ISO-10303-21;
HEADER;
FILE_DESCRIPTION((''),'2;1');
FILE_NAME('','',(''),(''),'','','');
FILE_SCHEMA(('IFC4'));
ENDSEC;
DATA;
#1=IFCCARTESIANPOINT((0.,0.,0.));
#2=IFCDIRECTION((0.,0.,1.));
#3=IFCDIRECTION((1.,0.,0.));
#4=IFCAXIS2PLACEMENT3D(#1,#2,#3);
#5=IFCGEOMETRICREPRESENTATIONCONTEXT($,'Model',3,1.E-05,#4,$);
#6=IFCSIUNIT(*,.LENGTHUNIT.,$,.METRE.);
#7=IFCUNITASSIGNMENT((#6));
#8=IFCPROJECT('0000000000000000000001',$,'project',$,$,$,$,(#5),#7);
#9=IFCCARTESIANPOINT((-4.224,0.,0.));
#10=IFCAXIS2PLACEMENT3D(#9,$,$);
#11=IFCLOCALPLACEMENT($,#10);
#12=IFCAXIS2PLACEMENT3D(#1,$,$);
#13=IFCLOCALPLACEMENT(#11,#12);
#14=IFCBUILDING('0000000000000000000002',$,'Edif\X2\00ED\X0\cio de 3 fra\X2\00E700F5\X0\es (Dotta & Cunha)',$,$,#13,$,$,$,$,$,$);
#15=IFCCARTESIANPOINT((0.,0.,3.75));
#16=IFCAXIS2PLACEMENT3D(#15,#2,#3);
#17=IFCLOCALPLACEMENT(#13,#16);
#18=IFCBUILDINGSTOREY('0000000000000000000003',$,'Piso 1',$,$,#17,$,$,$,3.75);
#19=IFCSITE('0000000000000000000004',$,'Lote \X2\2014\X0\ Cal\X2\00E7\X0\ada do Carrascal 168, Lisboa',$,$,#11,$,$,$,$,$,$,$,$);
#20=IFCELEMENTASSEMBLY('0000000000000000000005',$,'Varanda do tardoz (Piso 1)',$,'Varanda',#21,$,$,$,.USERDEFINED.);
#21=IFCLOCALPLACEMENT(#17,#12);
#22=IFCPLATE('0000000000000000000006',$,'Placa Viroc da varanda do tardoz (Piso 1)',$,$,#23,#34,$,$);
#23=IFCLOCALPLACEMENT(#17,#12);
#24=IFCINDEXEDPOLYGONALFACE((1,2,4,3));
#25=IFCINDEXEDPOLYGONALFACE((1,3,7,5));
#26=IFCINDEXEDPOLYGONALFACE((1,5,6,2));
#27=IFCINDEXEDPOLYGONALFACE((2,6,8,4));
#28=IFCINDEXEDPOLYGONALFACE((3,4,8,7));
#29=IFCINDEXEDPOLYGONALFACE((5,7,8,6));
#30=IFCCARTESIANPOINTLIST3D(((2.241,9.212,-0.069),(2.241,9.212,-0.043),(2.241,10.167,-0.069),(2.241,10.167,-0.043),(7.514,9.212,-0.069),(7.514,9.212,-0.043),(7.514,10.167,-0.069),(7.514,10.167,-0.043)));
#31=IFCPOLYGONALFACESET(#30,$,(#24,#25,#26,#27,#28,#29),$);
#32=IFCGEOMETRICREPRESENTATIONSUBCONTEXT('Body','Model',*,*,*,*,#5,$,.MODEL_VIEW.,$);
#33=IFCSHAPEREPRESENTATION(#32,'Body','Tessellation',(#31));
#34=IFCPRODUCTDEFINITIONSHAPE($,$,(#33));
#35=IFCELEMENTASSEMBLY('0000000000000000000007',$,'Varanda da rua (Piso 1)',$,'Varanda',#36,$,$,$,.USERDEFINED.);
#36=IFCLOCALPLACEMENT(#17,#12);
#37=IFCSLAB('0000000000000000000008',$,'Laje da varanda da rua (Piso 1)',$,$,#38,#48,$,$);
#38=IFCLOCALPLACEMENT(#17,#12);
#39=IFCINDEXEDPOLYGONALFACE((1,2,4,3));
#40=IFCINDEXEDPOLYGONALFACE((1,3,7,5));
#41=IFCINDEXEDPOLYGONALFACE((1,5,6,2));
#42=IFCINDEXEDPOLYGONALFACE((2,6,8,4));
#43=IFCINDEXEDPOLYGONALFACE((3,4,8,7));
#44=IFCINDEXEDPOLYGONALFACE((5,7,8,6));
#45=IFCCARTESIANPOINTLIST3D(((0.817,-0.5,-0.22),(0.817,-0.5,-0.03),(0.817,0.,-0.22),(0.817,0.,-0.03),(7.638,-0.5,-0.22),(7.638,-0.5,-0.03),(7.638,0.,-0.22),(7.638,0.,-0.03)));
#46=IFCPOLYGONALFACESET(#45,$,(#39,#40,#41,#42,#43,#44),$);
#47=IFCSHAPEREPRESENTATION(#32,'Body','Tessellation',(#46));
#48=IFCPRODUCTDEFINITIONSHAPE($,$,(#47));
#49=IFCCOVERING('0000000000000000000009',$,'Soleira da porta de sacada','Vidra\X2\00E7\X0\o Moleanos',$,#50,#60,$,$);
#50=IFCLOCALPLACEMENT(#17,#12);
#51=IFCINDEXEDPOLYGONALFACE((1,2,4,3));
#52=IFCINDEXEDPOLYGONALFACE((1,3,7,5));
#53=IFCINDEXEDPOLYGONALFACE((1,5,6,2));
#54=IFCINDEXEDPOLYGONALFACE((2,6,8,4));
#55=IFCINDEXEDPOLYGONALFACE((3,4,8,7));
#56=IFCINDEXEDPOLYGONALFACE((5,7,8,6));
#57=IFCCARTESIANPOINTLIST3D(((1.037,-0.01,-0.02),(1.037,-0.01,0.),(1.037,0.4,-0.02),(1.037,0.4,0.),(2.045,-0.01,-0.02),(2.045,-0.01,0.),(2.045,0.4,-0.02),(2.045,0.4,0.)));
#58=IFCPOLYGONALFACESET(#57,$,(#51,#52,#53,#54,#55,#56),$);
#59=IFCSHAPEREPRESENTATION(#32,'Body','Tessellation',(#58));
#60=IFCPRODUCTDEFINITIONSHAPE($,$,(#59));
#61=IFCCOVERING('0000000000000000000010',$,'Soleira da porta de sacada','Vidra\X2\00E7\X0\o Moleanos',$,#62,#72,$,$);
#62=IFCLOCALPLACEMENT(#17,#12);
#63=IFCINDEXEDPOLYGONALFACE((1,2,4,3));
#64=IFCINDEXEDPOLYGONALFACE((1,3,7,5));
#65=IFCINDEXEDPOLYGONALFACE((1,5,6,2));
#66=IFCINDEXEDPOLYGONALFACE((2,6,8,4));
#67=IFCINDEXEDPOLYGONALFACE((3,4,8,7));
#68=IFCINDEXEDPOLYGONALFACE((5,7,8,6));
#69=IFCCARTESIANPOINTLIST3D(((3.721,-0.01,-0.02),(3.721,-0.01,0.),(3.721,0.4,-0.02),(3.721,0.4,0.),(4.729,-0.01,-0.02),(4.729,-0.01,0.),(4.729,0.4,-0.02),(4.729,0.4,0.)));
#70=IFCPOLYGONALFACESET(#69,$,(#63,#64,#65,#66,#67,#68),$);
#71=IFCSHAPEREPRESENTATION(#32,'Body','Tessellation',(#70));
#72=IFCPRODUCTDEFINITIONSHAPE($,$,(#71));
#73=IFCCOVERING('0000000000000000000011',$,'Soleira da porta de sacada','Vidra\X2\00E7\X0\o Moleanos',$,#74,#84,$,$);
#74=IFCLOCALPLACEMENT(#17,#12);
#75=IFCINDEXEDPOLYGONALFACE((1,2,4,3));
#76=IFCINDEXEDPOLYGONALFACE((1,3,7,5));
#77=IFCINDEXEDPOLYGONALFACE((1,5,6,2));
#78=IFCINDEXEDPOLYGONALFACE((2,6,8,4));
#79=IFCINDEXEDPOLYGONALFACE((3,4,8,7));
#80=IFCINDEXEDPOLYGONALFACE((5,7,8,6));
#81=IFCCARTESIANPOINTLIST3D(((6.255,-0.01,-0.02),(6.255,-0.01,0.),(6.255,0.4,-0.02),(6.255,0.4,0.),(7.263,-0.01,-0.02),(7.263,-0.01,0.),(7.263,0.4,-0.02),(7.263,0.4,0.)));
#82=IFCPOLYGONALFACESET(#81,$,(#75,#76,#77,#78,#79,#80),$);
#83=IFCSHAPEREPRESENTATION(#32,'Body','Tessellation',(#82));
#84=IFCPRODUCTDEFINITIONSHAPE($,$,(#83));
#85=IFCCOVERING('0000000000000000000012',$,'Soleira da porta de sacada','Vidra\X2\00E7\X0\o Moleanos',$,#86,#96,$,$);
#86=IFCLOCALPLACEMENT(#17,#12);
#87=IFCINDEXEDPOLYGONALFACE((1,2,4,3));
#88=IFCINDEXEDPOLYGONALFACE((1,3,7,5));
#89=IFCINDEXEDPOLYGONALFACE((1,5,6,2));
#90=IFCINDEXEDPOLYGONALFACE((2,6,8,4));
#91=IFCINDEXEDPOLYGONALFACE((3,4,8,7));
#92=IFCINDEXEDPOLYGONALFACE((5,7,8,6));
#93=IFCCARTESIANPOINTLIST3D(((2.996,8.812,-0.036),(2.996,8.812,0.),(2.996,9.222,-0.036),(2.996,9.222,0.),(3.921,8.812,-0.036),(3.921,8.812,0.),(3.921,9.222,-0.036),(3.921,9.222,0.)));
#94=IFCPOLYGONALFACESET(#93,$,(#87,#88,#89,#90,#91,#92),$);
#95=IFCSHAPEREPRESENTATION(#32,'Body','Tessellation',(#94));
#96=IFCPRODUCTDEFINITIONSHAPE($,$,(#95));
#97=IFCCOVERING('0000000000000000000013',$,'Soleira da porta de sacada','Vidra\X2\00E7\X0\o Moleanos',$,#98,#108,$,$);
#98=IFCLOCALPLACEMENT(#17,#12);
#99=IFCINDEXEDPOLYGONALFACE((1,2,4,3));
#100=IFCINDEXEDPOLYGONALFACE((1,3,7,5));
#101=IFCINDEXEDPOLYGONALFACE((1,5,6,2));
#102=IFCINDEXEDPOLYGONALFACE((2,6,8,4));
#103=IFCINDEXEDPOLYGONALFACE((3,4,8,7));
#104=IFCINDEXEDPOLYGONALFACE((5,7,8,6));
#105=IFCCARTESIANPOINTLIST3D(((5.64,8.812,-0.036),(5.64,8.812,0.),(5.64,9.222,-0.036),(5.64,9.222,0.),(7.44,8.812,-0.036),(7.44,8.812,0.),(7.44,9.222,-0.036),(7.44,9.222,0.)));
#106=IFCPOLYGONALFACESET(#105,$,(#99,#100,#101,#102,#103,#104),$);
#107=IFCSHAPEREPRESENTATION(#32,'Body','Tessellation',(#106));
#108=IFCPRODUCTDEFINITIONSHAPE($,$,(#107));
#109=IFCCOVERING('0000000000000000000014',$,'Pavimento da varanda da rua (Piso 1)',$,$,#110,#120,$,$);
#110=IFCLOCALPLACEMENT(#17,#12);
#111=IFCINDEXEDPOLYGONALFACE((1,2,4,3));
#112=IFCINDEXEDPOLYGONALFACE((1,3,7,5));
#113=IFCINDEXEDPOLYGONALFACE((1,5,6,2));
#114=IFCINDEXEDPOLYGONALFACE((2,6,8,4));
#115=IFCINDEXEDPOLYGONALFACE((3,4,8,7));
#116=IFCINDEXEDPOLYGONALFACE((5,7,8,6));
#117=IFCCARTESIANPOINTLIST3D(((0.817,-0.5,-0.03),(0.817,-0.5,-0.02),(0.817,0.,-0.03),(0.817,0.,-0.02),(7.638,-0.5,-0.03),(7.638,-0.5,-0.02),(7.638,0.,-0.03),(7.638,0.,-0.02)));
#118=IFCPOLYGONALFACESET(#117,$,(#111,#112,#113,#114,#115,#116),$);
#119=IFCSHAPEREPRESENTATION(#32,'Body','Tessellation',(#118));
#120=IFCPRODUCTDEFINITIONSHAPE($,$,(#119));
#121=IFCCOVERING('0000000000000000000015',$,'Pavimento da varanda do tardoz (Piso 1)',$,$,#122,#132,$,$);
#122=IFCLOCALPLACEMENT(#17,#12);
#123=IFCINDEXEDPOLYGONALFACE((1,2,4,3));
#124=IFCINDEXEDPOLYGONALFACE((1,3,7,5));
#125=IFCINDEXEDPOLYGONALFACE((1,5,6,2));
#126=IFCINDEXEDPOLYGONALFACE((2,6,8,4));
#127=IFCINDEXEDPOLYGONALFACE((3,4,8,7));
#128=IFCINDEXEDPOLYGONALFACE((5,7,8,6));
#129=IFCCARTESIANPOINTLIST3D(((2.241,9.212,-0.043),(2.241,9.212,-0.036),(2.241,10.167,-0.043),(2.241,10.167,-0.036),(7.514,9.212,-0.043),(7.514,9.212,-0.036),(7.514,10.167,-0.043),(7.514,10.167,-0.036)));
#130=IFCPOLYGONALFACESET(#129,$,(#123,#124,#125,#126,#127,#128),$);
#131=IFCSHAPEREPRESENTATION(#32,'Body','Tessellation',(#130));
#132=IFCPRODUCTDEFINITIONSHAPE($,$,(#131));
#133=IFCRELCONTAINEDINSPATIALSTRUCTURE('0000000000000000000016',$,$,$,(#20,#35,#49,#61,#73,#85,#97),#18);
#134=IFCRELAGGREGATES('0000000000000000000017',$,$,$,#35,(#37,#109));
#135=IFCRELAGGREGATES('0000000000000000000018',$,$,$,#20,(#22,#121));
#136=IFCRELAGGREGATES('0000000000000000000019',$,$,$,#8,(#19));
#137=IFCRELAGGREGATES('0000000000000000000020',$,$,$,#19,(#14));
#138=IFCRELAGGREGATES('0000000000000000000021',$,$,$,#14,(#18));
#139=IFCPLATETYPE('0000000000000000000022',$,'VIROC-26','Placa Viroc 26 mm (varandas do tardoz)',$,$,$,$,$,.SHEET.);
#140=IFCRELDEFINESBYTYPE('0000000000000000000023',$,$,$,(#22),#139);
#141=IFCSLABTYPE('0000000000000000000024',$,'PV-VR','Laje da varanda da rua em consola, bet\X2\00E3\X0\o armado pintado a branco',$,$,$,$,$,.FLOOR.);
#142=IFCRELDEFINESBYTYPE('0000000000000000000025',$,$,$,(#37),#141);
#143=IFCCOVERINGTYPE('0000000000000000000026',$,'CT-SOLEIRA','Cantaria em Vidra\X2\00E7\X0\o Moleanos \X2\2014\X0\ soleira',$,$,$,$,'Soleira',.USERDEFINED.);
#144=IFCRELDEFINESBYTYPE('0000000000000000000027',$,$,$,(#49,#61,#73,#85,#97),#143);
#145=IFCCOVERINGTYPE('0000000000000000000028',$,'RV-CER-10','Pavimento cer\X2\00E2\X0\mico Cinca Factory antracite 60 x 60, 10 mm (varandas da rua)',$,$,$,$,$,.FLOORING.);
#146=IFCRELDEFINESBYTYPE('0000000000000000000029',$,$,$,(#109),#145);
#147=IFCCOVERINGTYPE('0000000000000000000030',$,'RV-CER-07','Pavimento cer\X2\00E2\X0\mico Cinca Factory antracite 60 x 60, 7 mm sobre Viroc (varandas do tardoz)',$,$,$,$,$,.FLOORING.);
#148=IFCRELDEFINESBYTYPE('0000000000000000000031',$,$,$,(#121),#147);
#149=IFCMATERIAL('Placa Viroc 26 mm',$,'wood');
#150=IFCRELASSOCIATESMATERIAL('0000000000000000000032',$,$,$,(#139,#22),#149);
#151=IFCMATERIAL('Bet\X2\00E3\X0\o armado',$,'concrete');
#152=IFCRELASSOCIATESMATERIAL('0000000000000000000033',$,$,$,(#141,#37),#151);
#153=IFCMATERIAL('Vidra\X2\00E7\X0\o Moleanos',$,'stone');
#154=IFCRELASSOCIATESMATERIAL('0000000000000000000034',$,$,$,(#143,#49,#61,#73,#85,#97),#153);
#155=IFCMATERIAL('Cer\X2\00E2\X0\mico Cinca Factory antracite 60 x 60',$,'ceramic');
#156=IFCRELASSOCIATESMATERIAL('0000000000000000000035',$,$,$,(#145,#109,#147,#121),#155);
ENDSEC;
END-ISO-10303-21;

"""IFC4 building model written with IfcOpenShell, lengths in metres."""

from ifc_helpers import new_model, si_unit, frame, origin, origin_with_axes, place, context, subcontext, project, spatial, line, indexed_curve, outline, extrude, material, type_object, element, aggregate, save


model = new_model("IFC4")

# Units and contexts
model_context = context("Model", 3, precision=1e-05, world=origin_with_axes())
body_context = subcontext(model_context, "Body", "Model", "MODEL_VIEW")
ifc_project = project(units=[si_unit("LENGTHUNIT", "METRE")], contexts=[model_context])

# Site, building, storey
site_placement = place(None, frame((-4.224, 0.0, 0.0)))
site = spatial("IfcSite", under=ifc_project, at=site_placement, Name="Lote — Calçada do Carrascal 168, Lisboa")
building_placement = place(site_placement, origin())
building = spatial("IfcBuilding", under=site, at=building_placement, Name="Edifício de 3 frações (Dotta & Cunha)")
storey_placement = place(building_placement, frame((0.0, 0.0, 3.75), z_axis=(0.0, 0.0, 1.0), x_axis=(1.0, 0.0, 0.0)))
storey = spatial("IfcBuildingStorey", under=building, at=storey_placement, Name="Piso 1", Elevation=3.75)

# Element assembly, plate
assembly_1 = element("IfcElementAssembly", 1, inside=storey, Name="Varanda do tardoz (Piso 1)", ObjectType="Varanda", PredefinedType="USERDEFINED")
ifc_material_1 = material(Name="Placa Viroc 26 mm", Category="wood")
plate_type = type_object("IfcPlateType", Name="VIROC-26", Description="Placa Viroc 26 mm (varandas do tardoz)", PredefinedType="SHEET", material=ifc_material_1)
plate_placement = place(building_placement, frame((0.0, 0.0, 3.681), z_axis=(0.0, 0.0, 1.0), x_axis=(1.0, 0.0, 0.0)))
plate = element("IfcPlate", 2, at=plate_placement, type_object=plate_type, material=ifc_material_1, Name="Placa Viroc da varanda do tardoz (Piso 1)", context=body_context, shape_type="SweptSolid", body=[
    extrude(outline(indexed_curve([(7.514, 9.212), (7.514, 10.167), (2.241, 10.167), (2.241, 9.212)], segments=[line(1, 2, 3, 4, 1)])), origin_with_axes(), (0.0, 0.0, 1.0), 0.026),
])

# Element assembly, slab
assembly_2 = element("IfcElementAssembly", 3, inside=storey, Name="Varanda da rua (Piso 1)", ObjectType="Varanda", PredefinedType="USERDEFINED")
ifc_material_2 = material(Name="Betão armado", Category="concrete")
slab_type = type_object("IfcSlabType", Name="PV-VR", Description="Laje da varanda da rua em consola, betão armado pintado a branco", PredefinedType="FLOOR", material=ifc_material_2)
slab_placement = place(building_placement, frame((0.0, 0.0, 3.53), z_axis=(0.0, 0.0, 1.0), x_axis=(1.0, 0.0, 0.0)))
slab = element("IfcSlab", 4, at=slab_placement, type_object=slab_type, material=ifc_material_2, Name="Laje da varanda da rua (Piso 1)", context=body_context, shape_type="SweptSolid", body=[
    extrude(outline(indexed_curve([(7.638, -0.5), (7.638, 0.0), (0.817, 0.0), (0.817, -0.5)], segments=[line(1, 2, 3, 4, 1)])), origin_with_axes(), (0.0, 0.0, 1.0), 0.19),
])

# Coverings
ifc_material_3 = material(Name="Vidraço Moleanos", Category="stone")
covering_type_1 = type_object("IfcCoveringType", Name="CT-SOLEIRA", Description="Cantaria em Vidraço Moleanos — soleira", ElementType="Soleira", PredefinedType="USERDEFINED", material=ifc_material_3)
covering_1_placement = place(storey_placement, frame((0.0, 0.0, -0.02), z_axis=(0.0, 0.0, 1.0), x_axis=(1.0, 0.0, 0.0)))
element("IfcCovering", 5, at=covering_1_placement, inside=storey, type_object=covering_type_1, material=ifc_material_3, Name="Soleira da porta de sacada", Description="Vidraço Moleanos", context=body_context, shape_type="SweptSolid", body=[
    extrude(outline(indexed_curve([(2.045, -0.01), (2.045, 0.4), (1.037, 0.4), (1.037, -0.01)], segments=[line(1, 2, 3, 4, 1)])), origin_with_axes(), (0.0, 0.0, 1.0), 0.02),
])
covering_2_placement = place(storey_placement, frame((0.0, 0.0, -0.02), z_axis=(0.0, 0.0, 1.0), x_axis=(1.0, 0.0, 0.0)))
element("IfcCovering", 6, at=covering_2_placement, inside=storey, type_object=covering_type_1, material=ifc_material_3, Name="Soleira da porta de sacada", Description="Vidraço Moleanos", context=body_context, shape_type="SweptSolid", body=[
    extrude(outline(indexed_curve([(4.729, -0.01), (4.729, 0.4), (3.721, 0.4), (3.721, -0.01)], segments=[line(1, 2, 3, 4, 1)])), origin_with_axes(), (0.0, 0.0, 1.0), 0.02),
])
covering_3_placement = place(storey_placement, frame((0.0, 0.0, -0.02), z_axis=(0.0, 0.0, 1.0), x_axis=(1.0, 0.0, 0.0)))
element("IfcCovering", 7, at=covering_3_placement, inside=storey, type_object=covering_type_1, material=ifc_material_3, Name="Soleira da porta de sacada", Description="Vidraço Moleanos", context=body_context, shape_type="SweptSolid", body=[
    extrude(outline(indexed_curve([(7.263, -0.01), (7.263, 0.4), (6.255, 0.4), (6.255, -0.01)], segments=[line(1, 2, 3, 4, 1)])), origin_with_axes(), (0.0, 0.0, 1.0), 0.02),
])
covering_4_placement = place(storey_placement, frame((0.0, 0.0, -0.036), z_axis=(0.0, 0.0, 1.0), x_axis=(1.0, 0.0, 0.0)))
element("IfcCovering", 8, at=covering_4_placement, inside=storey, type_object=covering_type_1, material=ifc_material_3, Name="Soleira da porta de sacada", Description="Vidraço Moleanos", context=body_context, shape_type="SweptSolid", body=[
    extrude(outline(indexed_curve([(3.921, 8.812), (3.921, 9.222), (2.996, 9.222), (2.996, 8.812)], segments=[line(1, 2, 3, 4, 1)])), origin_with_axes(), (0.0, 0.0, 1.0), 0.036),
])
covering_5_placement = place(storey_placement, frame((0.0, 0.0, -0.036), z_axis=(0.0, 0.0, 1.0), x_axis=(1.0, 0.0, 0.0)))
element("IfcCovering", 9, at=covering_5_placement, inside=storey, type_object=covering_type_1, material=ifc_material_3, Name="Soleira da porta de sacada", Description="Vidraço Moleanos", context=body_context, shape_type="SweptSolid", body=[
    extrude(outline(indexed_curve([(7.44, 8.812), (7.44, 9.222), (5.64, 9.222), (5.64, 8.812)], segments=[line(1, 2, 3, 4, 1)])), origin_with_axes(), (0.0, 0.0, 1.0), 0.036),
])

# Coverings
ifc_material_4 = material(Name="Cerâmico Cinca Factory antracite 60 x 60", Category="ceramic")
covering_type_2 = type_object("IfcCoveringType", Name="RV-CER-10", Description="Pavimento cerâmico Cinca Factory antracite 60 x 60, 10 mm (varandas da rua)", PredefinedType="FLOORING", material=ifc_material_4)
covering_6_placement = place(building_placement, frame((0.0, 0.0, 3.72), z_axis=(0.0, 0.0, 1.0), x_axis=(1.0, 0.0, 0.0)))
covering_6 = element("IfcCovering", 10, at=covering_6_placement, type_object=covering_type_2, material=ifc_material_4, Name="Pavimento da varanda da rua (Piso 1)", context=body_context, shape_type="SweptSolid", body=[
    extrude(outline(indexed_curve([(7.638, -0.5), (7.638, 0.0), (0.817, 0.0), (0.817, -0.5)], segments=[line(1, 2, 3, 4, 1)])), origin_with_axes(), (0.0, 0.0, 1.0), 0.01),
])
aggregate(assembly_2, [slab, covering_6])
covering_type_3 = type_object("IfcCoveringType", Name="RV-CER-07", Description="Pavimento cerâmico Cinca Factory antracite 60 x 60, 7 mm sobre Viroc (varandas do tardoz)", PredefinedType="FLOORING", material=ifc_material_4)
covering_7_placement = place(building_placement, frame((0.0, 0.0, 3.707), z_axis=(0.0, 0.0, 1.0), x_axis=(1.0, 0.0, 0.0)))
covering_7 = element("IfcCovering", 11, at=covering_7_placement, type_object=covering_type_3, material=ifc_material_4, Name="Pavimento da varanda do tardoz (Piso 1)", context=body_context, shape_type="SweptSolid", body=[
    extrude(outline(indexed_curve([(7.514, 9.212), (7.514, 10.167), (2.241, 10.167), (2.241, 9.212)], segments=[line(1, 2, 3, 4, 1)])), origin_with_axes(), (0.0, 0.0, 1.0), 0.007),
])
aggregate(assembly_1, [plate, covering_7])

save(model, "model.ifc")
